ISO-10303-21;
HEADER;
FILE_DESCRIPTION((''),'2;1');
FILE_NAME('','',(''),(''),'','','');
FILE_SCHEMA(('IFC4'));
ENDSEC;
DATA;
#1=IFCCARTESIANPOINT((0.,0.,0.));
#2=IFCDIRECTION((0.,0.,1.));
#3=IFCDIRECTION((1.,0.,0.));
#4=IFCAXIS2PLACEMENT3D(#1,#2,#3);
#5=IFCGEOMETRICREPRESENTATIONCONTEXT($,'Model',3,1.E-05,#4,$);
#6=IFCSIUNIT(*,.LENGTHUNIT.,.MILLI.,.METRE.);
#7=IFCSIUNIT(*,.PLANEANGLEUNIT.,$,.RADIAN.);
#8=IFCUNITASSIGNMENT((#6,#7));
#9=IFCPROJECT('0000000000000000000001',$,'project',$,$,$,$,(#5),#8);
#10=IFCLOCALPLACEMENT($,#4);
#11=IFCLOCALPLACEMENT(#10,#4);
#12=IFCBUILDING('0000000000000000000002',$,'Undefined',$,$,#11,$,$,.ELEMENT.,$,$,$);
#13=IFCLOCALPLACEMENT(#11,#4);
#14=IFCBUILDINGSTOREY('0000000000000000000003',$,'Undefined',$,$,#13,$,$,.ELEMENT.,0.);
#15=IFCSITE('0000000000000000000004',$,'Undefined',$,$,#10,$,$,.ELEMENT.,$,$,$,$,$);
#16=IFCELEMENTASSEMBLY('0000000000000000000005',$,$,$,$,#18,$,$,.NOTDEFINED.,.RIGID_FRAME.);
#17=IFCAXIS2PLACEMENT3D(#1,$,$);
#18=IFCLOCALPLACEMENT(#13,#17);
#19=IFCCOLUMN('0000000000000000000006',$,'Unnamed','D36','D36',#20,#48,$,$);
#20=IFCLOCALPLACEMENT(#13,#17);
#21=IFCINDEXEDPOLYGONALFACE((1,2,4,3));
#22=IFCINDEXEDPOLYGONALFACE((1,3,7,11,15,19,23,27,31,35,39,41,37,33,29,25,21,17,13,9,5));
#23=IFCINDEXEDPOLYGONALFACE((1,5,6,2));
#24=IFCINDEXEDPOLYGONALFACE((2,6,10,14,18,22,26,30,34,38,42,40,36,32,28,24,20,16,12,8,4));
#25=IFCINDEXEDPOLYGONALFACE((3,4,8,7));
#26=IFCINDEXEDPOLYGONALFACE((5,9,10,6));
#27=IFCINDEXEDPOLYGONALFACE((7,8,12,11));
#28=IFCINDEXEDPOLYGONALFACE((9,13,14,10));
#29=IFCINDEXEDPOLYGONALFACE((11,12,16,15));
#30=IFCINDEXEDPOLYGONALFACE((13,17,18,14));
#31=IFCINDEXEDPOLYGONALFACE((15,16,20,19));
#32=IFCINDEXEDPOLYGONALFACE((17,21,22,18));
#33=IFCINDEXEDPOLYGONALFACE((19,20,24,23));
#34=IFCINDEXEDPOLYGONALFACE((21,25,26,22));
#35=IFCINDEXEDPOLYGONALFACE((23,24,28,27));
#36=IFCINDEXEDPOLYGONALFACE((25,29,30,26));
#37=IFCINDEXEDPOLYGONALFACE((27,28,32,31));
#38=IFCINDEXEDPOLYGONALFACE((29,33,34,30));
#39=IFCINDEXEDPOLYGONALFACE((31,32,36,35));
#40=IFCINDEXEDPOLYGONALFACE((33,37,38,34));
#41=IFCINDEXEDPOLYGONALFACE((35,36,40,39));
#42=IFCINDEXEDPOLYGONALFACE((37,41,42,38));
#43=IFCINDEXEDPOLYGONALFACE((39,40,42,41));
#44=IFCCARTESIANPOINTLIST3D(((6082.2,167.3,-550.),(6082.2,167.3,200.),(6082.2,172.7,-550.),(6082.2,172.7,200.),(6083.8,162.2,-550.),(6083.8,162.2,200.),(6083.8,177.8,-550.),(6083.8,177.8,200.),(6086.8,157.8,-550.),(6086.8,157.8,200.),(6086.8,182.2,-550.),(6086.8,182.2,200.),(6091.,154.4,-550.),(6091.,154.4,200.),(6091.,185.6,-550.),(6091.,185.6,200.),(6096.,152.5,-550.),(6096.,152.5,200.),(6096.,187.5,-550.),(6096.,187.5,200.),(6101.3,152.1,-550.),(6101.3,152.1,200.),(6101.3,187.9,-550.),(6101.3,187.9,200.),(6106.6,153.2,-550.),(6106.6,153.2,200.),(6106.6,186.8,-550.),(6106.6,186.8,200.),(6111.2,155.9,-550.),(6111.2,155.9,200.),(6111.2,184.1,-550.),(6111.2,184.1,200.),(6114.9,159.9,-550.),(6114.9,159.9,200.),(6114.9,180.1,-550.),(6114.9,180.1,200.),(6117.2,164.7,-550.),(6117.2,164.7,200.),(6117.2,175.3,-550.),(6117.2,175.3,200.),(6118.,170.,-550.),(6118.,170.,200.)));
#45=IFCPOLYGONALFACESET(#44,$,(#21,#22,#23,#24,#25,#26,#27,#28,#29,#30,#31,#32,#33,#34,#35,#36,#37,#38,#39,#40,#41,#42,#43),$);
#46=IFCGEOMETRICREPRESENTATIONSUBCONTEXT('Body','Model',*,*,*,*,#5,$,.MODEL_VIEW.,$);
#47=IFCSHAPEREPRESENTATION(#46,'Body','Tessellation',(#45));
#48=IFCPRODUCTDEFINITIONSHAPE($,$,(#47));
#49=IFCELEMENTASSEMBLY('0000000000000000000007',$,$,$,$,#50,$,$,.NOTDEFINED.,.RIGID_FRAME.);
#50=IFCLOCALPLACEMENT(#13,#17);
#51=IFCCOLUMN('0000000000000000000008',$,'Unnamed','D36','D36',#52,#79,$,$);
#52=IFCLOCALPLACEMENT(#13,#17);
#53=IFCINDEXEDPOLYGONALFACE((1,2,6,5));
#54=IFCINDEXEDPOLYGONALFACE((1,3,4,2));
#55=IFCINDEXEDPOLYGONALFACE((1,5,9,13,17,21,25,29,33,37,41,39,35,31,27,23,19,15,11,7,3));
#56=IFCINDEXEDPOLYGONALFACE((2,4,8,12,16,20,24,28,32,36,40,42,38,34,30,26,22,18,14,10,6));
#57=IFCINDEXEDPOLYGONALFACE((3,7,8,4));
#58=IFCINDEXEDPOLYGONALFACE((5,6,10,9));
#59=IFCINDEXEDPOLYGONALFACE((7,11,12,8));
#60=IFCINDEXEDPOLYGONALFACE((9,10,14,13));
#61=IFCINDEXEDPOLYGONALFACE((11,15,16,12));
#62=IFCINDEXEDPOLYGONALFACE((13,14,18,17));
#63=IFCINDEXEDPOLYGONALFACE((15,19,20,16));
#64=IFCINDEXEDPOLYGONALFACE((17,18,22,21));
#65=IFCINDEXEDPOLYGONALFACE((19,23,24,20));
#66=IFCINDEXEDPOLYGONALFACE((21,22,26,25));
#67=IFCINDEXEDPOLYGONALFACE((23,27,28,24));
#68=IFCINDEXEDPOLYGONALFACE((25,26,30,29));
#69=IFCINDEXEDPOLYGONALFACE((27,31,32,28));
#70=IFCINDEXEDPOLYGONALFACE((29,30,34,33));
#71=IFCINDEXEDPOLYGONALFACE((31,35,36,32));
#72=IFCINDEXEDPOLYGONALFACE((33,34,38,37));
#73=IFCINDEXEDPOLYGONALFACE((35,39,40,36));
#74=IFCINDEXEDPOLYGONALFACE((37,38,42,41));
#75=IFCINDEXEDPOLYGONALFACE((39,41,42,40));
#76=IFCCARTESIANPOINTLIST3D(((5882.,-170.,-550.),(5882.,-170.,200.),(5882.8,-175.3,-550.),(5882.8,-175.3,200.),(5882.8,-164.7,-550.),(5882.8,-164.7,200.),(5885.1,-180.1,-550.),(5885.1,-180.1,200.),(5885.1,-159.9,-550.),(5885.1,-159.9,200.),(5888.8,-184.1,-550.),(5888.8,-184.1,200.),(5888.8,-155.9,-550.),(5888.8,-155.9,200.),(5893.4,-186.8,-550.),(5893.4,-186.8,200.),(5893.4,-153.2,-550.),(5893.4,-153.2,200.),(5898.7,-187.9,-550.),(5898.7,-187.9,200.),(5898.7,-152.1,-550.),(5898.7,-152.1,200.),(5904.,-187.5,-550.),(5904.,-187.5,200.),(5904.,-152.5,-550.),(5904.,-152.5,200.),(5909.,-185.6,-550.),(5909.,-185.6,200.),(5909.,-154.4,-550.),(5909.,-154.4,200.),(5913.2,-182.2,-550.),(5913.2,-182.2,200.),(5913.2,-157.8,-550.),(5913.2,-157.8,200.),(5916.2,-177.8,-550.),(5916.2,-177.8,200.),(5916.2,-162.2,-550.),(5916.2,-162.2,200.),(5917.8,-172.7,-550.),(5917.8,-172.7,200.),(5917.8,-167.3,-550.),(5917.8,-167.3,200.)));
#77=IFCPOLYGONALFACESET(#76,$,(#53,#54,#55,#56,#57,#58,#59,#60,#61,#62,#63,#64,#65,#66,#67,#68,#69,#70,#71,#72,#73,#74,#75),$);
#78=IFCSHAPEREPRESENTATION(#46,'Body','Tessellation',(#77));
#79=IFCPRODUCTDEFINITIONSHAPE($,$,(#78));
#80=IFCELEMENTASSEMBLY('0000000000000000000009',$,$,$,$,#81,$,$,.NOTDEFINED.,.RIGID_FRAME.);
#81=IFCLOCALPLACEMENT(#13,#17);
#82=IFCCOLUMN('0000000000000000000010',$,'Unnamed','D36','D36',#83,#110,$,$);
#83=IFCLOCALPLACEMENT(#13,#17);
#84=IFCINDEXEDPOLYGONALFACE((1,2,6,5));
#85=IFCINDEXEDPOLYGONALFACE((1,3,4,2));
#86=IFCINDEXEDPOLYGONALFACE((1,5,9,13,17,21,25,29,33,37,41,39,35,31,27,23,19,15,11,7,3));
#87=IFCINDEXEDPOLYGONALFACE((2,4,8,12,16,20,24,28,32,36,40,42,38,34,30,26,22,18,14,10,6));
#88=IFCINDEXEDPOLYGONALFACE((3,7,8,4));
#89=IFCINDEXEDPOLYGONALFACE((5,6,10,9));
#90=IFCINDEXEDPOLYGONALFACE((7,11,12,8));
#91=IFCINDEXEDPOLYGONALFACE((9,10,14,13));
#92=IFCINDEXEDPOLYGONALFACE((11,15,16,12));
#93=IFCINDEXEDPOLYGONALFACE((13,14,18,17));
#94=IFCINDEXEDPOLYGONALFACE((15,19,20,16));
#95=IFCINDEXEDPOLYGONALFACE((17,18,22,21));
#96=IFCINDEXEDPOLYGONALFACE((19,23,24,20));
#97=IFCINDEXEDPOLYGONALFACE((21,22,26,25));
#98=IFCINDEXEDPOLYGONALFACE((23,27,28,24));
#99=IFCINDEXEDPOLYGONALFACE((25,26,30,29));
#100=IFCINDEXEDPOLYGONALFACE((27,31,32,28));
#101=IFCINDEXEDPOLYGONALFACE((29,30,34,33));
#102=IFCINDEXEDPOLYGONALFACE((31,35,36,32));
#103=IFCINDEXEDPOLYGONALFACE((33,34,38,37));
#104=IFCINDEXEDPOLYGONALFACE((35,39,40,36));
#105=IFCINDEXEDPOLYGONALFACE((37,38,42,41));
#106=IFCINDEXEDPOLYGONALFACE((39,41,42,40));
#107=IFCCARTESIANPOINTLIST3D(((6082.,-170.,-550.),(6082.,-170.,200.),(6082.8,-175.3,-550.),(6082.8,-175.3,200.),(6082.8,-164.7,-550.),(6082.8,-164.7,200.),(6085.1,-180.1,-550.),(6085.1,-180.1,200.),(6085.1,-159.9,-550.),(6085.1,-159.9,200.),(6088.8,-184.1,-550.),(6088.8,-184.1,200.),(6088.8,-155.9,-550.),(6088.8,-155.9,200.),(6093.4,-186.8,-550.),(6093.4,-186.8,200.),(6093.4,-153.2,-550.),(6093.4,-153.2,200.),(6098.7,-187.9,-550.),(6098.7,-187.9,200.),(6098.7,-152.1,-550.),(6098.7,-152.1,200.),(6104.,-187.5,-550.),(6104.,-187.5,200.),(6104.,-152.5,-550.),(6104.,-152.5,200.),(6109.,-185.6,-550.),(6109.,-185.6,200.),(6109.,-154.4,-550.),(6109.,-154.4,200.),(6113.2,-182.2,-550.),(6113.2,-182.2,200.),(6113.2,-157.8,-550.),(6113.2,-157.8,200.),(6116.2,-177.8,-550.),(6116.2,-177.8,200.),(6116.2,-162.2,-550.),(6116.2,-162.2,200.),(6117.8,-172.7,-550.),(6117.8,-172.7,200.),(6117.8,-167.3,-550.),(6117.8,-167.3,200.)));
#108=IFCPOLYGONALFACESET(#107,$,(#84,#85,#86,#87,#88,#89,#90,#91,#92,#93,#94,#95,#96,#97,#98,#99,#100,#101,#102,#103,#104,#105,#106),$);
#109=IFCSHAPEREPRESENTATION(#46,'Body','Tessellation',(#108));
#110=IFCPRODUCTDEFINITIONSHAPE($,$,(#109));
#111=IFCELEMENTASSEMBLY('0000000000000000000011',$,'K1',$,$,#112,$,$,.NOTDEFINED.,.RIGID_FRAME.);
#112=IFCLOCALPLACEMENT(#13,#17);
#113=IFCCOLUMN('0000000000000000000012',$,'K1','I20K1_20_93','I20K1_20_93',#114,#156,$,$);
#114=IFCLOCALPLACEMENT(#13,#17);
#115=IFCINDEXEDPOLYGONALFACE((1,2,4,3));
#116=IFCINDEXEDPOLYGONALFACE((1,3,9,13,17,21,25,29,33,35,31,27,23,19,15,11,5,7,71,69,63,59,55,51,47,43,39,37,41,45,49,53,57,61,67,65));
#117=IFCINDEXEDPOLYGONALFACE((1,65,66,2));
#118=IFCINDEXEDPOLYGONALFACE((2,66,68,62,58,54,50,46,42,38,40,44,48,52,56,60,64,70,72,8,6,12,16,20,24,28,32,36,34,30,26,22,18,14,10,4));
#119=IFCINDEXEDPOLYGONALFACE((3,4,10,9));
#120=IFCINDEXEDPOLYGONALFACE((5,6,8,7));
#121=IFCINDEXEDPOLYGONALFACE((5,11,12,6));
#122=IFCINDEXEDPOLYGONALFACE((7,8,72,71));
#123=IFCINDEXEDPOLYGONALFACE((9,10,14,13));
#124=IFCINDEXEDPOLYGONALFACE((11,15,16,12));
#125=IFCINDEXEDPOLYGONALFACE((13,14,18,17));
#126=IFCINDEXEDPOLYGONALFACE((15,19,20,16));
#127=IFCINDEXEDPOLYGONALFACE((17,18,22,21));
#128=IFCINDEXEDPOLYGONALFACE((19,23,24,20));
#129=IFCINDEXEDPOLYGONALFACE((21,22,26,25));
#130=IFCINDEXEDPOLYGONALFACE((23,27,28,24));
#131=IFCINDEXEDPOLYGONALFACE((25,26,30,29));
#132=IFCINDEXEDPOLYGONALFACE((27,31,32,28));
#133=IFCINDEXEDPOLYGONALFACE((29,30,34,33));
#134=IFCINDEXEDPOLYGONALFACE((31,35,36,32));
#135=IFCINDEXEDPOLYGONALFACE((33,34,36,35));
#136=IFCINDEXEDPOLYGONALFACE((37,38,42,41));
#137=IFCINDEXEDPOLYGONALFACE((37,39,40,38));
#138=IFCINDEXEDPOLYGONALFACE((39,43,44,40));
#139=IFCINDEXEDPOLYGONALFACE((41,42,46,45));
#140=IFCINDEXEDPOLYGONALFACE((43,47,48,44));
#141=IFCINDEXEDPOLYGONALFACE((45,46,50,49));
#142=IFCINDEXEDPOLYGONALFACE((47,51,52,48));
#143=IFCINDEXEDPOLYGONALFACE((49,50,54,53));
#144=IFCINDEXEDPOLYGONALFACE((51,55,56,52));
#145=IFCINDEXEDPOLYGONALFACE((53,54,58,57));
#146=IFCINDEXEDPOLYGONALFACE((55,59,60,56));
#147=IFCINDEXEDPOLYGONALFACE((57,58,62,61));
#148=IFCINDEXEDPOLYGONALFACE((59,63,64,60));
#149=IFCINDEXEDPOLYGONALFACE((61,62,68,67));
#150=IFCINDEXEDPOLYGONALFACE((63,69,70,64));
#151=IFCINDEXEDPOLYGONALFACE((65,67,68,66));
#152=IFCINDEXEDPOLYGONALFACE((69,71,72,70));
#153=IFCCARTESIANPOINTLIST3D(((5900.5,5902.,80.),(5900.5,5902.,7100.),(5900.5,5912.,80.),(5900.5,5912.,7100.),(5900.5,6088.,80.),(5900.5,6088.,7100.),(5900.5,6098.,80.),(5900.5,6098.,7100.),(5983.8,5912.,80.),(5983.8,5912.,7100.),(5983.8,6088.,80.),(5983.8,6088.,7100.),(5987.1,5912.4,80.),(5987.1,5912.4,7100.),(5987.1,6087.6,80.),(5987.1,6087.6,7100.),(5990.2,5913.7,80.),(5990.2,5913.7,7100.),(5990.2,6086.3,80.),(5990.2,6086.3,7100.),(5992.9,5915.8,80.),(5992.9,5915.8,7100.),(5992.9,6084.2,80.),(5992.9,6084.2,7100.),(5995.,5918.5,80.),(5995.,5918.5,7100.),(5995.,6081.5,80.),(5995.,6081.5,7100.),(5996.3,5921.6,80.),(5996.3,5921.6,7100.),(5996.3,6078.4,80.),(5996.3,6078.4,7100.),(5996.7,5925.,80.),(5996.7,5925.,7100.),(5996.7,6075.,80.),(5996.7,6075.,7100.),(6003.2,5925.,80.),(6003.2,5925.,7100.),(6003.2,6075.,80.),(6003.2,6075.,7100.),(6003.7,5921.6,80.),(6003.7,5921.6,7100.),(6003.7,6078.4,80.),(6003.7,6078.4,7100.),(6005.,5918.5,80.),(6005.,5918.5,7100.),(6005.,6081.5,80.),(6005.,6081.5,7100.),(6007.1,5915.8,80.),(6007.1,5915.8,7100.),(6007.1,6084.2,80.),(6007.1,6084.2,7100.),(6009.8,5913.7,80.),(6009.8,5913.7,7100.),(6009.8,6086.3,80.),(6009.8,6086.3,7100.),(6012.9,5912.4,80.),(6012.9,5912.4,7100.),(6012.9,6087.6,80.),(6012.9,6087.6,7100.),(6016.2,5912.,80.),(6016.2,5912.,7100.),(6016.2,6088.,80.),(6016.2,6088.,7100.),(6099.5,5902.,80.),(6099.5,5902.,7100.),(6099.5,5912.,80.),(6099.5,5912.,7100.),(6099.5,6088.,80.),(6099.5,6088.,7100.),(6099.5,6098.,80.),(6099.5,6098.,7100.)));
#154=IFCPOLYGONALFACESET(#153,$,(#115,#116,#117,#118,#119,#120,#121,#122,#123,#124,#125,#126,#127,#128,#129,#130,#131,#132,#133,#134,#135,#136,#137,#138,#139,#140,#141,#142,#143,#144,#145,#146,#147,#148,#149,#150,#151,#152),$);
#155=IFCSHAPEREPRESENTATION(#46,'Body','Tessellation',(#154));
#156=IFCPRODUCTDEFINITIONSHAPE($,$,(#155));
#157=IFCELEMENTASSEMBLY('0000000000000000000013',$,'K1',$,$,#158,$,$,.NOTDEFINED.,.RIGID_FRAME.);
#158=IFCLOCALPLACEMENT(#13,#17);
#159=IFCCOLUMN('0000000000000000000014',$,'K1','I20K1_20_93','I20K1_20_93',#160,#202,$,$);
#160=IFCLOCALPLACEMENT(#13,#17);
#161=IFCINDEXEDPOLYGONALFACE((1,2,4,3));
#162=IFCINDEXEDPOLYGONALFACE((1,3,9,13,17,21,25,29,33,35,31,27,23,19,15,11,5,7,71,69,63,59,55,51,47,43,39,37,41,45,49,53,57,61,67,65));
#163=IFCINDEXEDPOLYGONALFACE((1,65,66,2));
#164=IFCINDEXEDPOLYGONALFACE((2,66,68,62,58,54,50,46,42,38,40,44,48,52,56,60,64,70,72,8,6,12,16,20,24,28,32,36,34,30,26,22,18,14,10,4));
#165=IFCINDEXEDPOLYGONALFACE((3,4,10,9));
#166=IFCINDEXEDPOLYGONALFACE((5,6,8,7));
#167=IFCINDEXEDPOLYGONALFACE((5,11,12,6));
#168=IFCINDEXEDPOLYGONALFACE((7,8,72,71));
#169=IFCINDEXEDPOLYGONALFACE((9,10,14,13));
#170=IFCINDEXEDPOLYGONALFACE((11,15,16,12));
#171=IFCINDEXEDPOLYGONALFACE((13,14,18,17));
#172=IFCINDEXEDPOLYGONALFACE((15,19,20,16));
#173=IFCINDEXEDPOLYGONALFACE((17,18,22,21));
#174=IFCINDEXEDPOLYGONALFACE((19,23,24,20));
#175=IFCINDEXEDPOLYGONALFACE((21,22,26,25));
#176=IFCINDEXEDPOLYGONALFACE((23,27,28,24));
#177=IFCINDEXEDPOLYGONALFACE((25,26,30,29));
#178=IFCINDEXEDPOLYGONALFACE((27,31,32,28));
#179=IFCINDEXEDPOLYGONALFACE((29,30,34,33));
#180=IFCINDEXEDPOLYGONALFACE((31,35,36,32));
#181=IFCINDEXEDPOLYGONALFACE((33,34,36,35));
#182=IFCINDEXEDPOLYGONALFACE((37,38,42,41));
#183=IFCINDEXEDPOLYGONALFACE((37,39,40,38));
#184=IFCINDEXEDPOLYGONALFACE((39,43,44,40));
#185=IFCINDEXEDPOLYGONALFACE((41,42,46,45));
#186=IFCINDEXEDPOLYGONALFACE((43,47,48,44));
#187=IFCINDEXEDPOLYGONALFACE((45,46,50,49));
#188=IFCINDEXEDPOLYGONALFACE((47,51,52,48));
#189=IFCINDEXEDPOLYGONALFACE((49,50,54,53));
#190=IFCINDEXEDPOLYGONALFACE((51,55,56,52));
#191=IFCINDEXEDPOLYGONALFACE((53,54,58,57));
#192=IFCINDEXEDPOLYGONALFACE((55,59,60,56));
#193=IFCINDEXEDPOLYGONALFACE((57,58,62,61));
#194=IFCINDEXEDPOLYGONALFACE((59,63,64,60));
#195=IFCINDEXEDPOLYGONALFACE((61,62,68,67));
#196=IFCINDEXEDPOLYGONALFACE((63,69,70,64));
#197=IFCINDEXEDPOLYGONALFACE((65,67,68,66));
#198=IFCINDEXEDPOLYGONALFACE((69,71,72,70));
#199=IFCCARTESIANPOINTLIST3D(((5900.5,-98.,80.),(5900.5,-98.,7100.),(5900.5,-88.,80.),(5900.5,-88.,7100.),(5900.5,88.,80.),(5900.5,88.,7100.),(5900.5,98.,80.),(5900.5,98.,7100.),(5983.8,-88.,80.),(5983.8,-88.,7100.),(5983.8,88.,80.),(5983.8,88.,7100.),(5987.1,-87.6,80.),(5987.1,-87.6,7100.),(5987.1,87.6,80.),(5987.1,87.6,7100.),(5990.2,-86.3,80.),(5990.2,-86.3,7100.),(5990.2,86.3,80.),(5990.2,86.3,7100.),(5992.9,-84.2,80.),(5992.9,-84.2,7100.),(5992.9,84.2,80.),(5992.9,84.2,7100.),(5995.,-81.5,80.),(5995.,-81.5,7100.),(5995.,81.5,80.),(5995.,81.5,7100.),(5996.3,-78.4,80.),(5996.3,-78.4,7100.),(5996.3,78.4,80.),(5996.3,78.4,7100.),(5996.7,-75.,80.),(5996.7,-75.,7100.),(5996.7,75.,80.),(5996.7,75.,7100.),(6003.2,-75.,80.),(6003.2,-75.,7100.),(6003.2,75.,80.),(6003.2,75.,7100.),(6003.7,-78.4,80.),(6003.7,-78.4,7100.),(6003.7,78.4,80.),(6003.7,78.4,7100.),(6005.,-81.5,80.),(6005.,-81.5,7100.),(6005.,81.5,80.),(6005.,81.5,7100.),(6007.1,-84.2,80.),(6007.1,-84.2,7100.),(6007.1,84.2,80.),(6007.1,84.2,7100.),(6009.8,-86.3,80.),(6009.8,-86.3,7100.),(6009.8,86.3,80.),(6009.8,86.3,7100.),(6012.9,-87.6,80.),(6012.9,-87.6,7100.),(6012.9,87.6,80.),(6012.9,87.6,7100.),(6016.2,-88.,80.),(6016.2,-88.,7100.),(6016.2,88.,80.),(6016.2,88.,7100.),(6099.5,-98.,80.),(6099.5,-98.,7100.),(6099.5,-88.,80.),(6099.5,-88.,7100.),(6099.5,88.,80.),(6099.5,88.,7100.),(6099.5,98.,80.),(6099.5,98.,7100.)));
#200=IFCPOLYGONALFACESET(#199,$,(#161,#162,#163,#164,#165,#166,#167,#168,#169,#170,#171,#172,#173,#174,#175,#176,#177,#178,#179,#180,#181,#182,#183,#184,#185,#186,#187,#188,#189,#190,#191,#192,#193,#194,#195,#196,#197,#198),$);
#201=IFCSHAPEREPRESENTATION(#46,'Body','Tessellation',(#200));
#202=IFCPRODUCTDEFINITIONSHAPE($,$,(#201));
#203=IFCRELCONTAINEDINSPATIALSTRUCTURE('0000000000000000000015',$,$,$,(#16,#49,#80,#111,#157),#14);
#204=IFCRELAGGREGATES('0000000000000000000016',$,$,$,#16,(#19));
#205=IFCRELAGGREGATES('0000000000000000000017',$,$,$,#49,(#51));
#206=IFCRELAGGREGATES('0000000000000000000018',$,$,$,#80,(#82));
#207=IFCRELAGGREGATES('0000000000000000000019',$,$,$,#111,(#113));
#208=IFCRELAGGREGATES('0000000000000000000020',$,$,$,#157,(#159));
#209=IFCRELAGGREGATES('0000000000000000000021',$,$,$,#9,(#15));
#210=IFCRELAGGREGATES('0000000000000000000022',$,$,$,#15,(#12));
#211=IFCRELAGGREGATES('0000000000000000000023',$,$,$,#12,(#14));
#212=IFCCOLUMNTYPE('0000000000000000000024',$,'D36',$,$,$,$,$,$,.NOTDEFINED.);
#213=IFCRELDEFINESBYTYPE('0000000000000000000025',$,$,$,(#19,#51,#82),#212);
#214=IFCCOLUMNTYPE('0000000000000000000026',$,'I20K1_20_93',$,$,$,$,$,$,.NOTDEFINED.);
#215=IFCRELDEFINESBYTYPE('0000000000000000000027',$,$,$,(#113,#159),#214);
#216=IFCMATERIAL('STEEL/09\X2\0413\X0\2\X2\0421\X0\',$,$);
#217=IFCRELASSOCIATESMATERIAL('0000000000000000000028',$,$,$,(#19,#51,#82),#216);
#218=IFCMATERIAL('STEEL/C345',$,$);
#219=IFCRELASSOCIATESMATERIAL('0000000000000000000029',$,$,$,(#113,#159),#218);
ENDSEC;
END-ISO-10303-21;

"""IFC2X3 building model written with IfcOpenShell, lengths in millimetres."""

from ifc_helpers import new_model, si_unit, frame, origin_with_axes, origin_2d_with_axis, place, context, subcontext, project, spatial, circle, i_section, extrude, material, type_object, element, aggregate, save


model = new_model("IFC2X3")

# Units and contexts
model_context = context("Model", 3, precision=1e-05, world=origin_with_axes())
body_context = subcontext(model_context, "Body", "Model", "MODEL_VIEW")
ifc_project = project(units=[si_unit("LENGTHUNIT", "METRE", prefix="MILLI"), si_unit("PLANEANGLEUNIT", "RADIAN")], contexts=[model_context])

# Site, building, storey
site_placement = place(None, origin_with_axes())
site = spatial("IfcSite", under=ifc_project, at=site_placement, Name="Undefined", CompositionType="ELEMENT")
building_placement = place(site_placement, origin_with_axes())
building = spatial("IfcBuilding", under=site, at=building_placement, Name="Undefined", CompositionType="ELEMENT")
storey_placement = place(building_placement, origin_with_axes())
storey = spatial("IfcBuildingStorey", under=building, at=storey_placement, Name="Undefined", CompositionType="ELEMENT", Elevation=0.0)

# Element assemblies, columns
ifc_material_1 = material(Name="STEEL/09Г2С")
column_type_1 = type_object("IfcColumnType", Name="D36", PredefinedType="NOTDEFINED")
assembly_1_placement = place(storey_placement, origin_with_axes())
assembly_1 = element("IfcElementAssembly", 1, at=assembly_1_placement, inside=storey, AssemblyPlace="NOTDEFINED", PredefinedType="RIGID_FRAME")
column_1_placement = place(assembly_1_placement, frame((6100.0, 170.0, -550.0), z_axis=(0.0, 0.0, 1.0), x_axis=(0.0, -1.0, 0.0)))
column_1 = element("IfcColumn", 2, at=column_1_placement, type_object=column_type_1, material=ifc_material_1, Name="Unnamed", Description="D36", ObjectType="D36", context=body_context, shape_type="SweptSolid", body=[
    extrude(circle(Radius=18.0, at=origin_2d_with_axis()), frame((0.0, 0.0, 750.0), z_axis=(0.0, 0.0, -1.0), x_axis=(0.0, 1.0, 0.0)), (0.0, 0.0, 1.0), 750.0),
])
aggregate(assembly_1, [column_1])
assembly_2_placement = place(storey_placement, origin_with_axes())
assembly_2 = element("IfcElementAssembly", 3, at=assembly_2_placement, inside=storey, AssemblyPlace="NOTDEFINED", PredefinedType="RIGID_FRAME")
column_2_placement = place(assembly_2_placement, frame((5900.0, -170.0, -550.0), z_axis=(0.0, 0.0, 1.0), x_axis=(0.0, 1.0, 0.0)))
column_2 = element("IfcColumn", 4, at=column_2_placement, type_object=column_type_1, material=ifc_material_1, Name="Unnamed", Description="D36", ObjectType="D36", context=body_context, shape_type="SweptSolid", body=[
    extrude(circle(Radius=18.0, at=origin_2d_with_axis()), frame((0.0, 0.0, 750.0), z_axis=(0.0, 0.0, -1.0), x_axis=(0.0, 1.0, 0.0)), (0.0, 0.0, 1.0), 750.0),
])
aggregate(assembly_2, [column_2])
assembly_3_placement = place(storey_placement, origin_with_axes())
assembly_3 = element("IfcElementAssembly", 5, at=assembly_3_placement, inside=storey, AssemblyPlace="NOTDEFINED", PredefinedType="RIGID_FRAME")
column_3_placement = place(assembly_3_placement, frame((6100.0, -170.0, -550.0), z_axis=(0.0, 0.0, 1.0), x_axis=(0.0, 1.0, 0.0)))
column_3 = element("IfcColumn", 6, at=column_3_placement, type_object=column_type_1, material=ifc_material_1, Name="Unnamed", Description="D36", ObjectType="D36", context=body_context, shape_type="SweptSolid", body=[
    extrude(circle(Radius=18.0, at=origin_2d_with_axis()), frame((0.0, 0.0, 750.0), z_axis=(0.0, 0.0, -1.0), x_axis=(0.0, 1.0, 0.0)), (0.0, 0.0, 1.0), 750.0),
])
aggregate(assembly_3, [column_3])
assembly_4_placement = place(storey_placement, origin_with_axes())
assembly_4 = element("IfcElementAssembly", 7, at=assembly_4_placement, inside=storey, Name="K1", AssemblyPlace="NOTDEFINED", PredefinedType="RIGID_FRAME")
ifc_material_2 = material(Name="STEEL/C345")
column_type_2 = type_object("IfcColumnType", Name="I20K1_20_93", PredefinedType="NOTDEFINED")
column_4_placement = place(assembly_4_placement, frame((6000.0, 6000.0, 80.0), z_axis=(0.0, 0.0, 1.0), x_axis=(0.0, 1.0, 0.0)))
column_4 = element("IfcColumn", 8, at=column_4_placement, type_object=column_type_2, material=ifc_material_2, Name="K1", Description="I20K1_20_93", ObjectType="I20K1_20_93", context=body_context, shape_type="SweptSolid", body=[
    extrude(i_section(OverallWidth=199.0, OverallDepth=196.0, WebThickness=6.5, FlangeThickness=10.0, FilletRadius=13.0, at=origin_2d_with_axis()), frame((0.0, 0.0, 7020.0), z_axis=(0.0, 0.0, -1.0), x_axis=(0.0, 1.0, 0.0)), (0.0, 0.0, 1.0), 7020.0),
])
assembly_5_placement = place(storey_placement, origin_with_axes())
assembly_5 = element("IfcElementAssembly", 9, at=assembly_5_placement, inside=storey, Name="K1", AssemblyPlace="NOTDEFINED", PredefinedType="RIGID_FRAME")
column_5_placement = place(assembly_5_placement, frame((6000.0, 0.0, 80.0), z_axis=(0.0, 0.0, 1.0), x_axis=(0.0, 1.0, 0.0)))
column_5 = element("IfcColumn", 10, at=column_5_placement, type_object=column_type_2, material=ifc_material_2, Name="K1", Description="I20K1_20_93", ObjectType="I20K1_20_93", context=body_context, shape_type="SweptSolid", body=[
    extrude(i_section(OverallWidth=199.0, OverallDepth=196.0, WebThickness=6.5, FlangeThickness=10.0, FilletRadius=13.0, at=origin_2d_with_axis()), frame((0.0, 0.0, 7020.0), z_axis=(0.0, 0.0, -1.0), x_axis=(0.0, 1.0, 0.0)), (0.0, 0.0, 1.0), 7020.0),
])

aggregate(assembly_4, [column_4])

aggregate(assembly_5, [column_5])

save(model, "model.ifc")
